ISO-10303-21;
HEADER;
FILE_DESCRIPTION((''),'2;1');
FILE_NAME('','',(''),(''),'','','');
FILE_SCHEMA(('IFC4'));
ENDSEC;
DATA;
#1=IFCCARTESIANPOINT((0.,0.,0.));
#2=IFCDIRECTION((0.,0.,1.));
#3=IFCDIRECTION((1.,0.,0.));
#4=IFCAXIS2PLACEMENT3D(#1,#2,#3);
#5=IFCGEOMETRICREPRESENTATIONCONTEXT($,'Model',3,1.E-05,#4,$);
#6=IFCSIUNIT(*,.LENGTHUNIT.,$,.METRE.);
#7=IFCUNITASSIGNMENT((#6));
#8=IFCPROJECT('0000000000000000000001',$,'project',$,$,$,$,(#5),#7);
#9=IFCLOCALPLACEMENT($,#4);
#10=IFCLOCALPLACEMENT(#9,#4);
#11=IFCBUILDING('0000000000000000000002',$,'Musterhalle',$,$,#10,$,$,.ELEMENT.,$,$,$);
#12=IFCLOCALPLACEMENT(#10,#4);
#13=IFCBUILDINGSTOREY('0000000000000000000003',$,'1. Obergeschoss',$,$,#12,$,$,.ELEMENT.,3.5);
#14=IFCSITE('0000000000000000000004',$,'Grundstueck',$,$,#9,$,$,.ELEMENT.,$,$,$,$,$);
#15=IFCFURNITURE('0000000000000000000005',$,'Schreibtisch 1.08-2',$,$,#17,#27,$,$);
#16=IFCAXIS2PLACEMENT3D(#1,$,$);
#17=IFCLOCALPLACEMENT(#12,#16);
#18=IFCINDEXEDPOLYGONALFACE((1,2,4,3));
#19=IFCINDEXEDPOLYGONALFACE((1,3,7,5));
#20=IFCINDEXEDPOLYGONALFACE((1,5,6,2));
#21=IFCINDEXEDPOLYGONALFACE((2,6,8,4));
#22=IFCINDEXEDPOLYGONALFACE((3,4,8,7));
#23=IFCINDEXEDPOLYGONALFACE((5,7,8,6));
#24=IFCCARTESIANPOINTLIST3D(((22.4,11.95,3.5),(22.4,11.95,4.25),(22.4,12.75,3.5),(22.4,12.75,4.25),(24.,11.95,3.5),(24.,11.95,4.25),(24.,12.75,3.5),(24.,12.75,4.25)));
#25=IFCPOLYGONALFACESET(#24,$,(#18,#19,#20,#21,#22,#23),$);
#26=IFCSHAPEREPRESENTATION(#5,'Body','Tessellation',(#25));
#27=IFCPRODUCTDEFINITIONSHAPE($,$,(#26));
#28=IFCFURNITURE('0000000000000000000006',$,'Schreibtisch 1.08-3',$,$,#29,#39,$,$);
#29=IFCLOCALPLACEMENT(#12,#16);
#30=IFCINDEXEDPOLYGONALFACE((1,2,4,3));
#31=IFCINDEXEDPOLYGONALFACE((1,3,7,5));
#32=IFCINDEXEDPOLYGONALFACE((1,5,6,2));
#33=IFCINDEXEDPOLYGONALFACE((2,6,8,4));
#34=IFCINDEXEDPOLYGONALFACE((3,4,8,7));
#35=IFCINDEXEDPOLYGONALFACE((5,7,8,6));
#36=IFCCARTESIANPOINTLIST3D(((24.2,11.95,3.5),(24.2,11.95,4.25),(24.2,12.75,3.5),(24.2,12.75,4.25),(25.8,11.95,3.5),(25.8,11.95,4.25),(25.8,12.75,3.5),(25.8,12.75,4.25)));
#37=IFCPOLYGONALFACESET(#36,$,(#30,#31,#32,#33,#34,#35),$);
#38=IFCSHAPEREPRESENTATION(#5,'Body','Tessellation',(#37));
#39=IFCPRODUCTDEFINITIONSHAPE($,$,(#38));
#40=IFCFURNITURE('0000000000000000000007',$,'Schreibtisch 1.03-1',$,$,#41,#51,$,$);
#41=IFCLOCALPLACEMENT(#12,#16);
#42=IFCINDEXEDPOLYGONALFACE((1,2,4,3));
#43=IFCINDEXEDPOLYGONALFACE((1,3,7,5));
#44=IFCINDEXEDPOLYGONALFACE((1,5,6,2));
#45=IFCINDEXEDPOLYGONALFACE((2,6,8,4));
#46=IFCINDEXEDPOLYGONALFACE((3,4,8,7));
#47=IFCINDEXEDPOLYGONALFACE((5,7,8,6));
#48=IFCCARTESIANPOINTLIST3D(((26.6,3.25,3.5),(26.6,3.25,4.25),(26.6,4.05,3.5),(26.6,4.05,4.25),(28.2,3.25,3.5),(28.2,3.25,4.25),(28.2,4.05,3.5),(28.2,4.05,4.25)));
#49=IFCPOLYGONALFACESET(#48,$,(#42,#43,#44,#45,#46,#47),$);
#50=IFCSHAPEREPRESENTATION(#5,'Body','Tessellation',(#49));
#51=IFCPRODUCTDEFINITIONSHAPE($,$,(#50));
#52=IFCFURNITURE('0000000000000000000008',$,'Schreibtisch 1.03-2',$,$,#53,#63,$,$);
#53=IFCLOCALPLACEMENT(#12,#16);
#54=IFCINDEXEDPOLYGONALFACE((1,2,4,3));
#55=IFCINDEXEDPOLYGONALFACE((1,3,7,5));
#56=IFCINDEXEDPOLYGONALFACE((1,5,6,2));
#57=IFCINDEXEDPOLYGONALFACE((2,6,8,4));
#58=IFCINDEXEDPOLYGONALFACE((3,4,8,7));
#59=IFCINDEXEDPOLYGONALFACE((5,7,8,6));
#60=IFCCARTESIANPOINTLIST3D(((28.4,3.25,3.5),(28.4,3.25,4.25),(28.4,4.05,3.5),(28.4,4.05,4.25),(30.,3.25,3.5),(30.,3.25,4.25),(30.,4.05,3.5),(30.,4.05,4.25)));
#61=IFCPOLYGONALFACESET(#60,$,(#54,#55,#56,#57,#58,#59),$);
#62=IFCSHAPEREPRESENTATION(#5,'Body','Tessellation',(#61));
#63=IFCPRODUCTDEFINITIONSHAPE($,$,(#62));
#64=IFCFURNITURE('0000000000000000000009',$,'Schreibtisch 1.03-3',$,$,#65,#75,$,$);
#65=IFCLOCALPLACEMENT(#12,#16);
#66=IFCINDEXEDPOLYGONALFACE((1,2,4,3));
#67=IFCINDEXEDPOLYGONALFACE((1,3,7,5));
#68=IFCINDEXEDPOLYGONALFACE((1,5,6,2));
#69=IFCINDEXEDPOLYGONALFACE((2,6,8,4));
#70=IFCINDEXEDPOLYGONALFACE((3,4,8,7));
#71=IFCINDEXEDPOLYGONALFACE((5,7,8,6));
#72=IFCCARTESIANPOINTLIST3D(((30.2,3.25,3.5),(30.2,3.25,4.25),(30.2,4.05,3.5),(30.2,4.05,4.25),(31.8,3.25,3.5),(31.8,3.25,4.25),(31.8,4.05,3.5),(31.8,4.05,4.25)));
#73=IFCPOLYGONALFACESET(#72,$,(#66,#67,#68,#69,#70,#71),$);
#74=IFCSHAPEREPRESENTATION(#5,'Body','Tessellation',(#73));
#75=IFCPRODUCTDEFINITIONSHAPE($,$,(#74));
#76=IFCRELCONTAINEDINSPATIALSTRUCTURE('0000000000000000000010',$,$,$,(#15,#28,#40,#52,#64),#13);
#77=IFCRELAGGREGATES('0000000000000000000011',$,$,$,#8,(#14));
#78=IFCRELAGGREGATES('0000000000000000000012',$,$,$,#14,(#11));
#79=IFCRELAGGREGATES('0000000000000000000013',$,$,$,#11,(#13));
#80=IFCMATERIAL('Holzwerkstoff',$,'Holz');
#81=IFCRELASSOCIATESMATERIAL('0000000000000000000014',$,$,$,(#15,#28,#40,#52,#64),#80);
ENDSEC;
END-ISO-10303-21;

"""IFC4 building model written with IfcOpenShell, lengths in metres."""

from ifc_helpers import new_model, si_unit, frame, origin_with_axes, origin_2d, place, context, project, spatial, rectangle, extrude, material, element, save


model = new_model("IFC4")

# Units and contexts
model_context = context("Model", 3, precision=1e-05, world=origin_with_axes())
ifc_project = project(units=[si_unit("LENGTHUNIT", "METRE")], contexts=[model_context])

# Site, building, storey
site_placement = place(None, origin_with_axes())
site = spatial("IfcSite", under=ifc_project, at=site_placement, Name="Grundstueck", CompositionType="ELEMENT")
building_placement = place(site_placement, origin_with_axes())
building = spatial("IfcBuilding", under=site, at=building_placement, Name="Musterhalle", CompositionType="ELEMENT")
storey_placement = place(building_placement, origin_with_axes())
storey = spatial("IfcBuildingStorey", under=building, at=storey_placement, Name="1. Obergeschoss", CompositionType="ELEMENT", Elevation=3.5)

# Shared definitions
placement = place(storey_placement, origin_with_axes())

# Shared definitions
ifc_material_1 = material(Name="Holzwerkstoff", Category="Holz")

# Furniture
element("IfcFurniture", 1, at=placement, inside=storey, material=ifc_material_1, Name="Schreibtisch 1.08-2", context=model_context, shape_type="SweptSolid", body=[
    extrude(rectangle(XDim=1.6, YDim=0.8, at=origin_2d()), frame((23.2, 12.35, 3.5), z_axis=(0.0, 0.0, 1.0), x_axis=(1.0, 0.0, 0.0)), (0.0, 0.0, 1.0), 0.75),
])
element("IfcFurniture", 2, at=placement, inside=storey, material=ifc_material_1, Name="Schreibtisch 1.08-3", context=model_context, shape_type="SweptSolid", body=[
    extrude(rectangle(XDim=1.6, YDim=0.8, at=origin_2d()), frame((25.0, 12.35, 3.5), z_axis=(0.0, 0.0, 1.0), x_axis=(1.0, 0.0, 0.0)), (0.0, 0.0, 1.0), 0.75),
])
element("IfcFurniture", 3, at=placement, inside=storey, material=ifc_material_1, Name="Schreibtisch 1.03-1", context=model_context, shape_type="SweptSolid", body=[
    extrude(rectangle(XDim=1.6, YDim=0.8, at=origin_2d()), frame((27.4, 3.65, 3.5), z_axis=(0.0, 0.0, 1.0), x_axis=(1.0, 0.0, 0.0)), (0.0, 0.0, 1.0), 0.75),
])
element("IfcFurniture", 4, at=placement, inside=storey, material=ifc_material_1, Name="Schreibtisch 1.03-2", context=model_context, shape_type="SweptSolid", body=[
    extrude(rectangle(XDim=1.6, YDim=0.8, at=origin_2d()), frame((29.2, 3.65, 3.5), z_axis=(0.0, 0.0, 1.0), x_axis=(1.0, 0.0, 0.0)), (0.0, 0.0, 1.0), 0.75),
])
element("IfcFurniture", 5, at=placement, inside=storey, material=ifc_material_1, Name="Schreibtisch 1.03-3", context=model_context, shape_type="SweptSolid", body=[
    extrude(rectangle(XDim=1.6, YDim=0.8, at=origin_2d()), frame((31.0, 3.65, 3.5), z_axis=(0.0, 0.0, 1.0), x_axis=(1.0, 0.0, 0.0)), (0.0, 0.0, 1.0), 0.75),
])

save(model, "model.ifc")
